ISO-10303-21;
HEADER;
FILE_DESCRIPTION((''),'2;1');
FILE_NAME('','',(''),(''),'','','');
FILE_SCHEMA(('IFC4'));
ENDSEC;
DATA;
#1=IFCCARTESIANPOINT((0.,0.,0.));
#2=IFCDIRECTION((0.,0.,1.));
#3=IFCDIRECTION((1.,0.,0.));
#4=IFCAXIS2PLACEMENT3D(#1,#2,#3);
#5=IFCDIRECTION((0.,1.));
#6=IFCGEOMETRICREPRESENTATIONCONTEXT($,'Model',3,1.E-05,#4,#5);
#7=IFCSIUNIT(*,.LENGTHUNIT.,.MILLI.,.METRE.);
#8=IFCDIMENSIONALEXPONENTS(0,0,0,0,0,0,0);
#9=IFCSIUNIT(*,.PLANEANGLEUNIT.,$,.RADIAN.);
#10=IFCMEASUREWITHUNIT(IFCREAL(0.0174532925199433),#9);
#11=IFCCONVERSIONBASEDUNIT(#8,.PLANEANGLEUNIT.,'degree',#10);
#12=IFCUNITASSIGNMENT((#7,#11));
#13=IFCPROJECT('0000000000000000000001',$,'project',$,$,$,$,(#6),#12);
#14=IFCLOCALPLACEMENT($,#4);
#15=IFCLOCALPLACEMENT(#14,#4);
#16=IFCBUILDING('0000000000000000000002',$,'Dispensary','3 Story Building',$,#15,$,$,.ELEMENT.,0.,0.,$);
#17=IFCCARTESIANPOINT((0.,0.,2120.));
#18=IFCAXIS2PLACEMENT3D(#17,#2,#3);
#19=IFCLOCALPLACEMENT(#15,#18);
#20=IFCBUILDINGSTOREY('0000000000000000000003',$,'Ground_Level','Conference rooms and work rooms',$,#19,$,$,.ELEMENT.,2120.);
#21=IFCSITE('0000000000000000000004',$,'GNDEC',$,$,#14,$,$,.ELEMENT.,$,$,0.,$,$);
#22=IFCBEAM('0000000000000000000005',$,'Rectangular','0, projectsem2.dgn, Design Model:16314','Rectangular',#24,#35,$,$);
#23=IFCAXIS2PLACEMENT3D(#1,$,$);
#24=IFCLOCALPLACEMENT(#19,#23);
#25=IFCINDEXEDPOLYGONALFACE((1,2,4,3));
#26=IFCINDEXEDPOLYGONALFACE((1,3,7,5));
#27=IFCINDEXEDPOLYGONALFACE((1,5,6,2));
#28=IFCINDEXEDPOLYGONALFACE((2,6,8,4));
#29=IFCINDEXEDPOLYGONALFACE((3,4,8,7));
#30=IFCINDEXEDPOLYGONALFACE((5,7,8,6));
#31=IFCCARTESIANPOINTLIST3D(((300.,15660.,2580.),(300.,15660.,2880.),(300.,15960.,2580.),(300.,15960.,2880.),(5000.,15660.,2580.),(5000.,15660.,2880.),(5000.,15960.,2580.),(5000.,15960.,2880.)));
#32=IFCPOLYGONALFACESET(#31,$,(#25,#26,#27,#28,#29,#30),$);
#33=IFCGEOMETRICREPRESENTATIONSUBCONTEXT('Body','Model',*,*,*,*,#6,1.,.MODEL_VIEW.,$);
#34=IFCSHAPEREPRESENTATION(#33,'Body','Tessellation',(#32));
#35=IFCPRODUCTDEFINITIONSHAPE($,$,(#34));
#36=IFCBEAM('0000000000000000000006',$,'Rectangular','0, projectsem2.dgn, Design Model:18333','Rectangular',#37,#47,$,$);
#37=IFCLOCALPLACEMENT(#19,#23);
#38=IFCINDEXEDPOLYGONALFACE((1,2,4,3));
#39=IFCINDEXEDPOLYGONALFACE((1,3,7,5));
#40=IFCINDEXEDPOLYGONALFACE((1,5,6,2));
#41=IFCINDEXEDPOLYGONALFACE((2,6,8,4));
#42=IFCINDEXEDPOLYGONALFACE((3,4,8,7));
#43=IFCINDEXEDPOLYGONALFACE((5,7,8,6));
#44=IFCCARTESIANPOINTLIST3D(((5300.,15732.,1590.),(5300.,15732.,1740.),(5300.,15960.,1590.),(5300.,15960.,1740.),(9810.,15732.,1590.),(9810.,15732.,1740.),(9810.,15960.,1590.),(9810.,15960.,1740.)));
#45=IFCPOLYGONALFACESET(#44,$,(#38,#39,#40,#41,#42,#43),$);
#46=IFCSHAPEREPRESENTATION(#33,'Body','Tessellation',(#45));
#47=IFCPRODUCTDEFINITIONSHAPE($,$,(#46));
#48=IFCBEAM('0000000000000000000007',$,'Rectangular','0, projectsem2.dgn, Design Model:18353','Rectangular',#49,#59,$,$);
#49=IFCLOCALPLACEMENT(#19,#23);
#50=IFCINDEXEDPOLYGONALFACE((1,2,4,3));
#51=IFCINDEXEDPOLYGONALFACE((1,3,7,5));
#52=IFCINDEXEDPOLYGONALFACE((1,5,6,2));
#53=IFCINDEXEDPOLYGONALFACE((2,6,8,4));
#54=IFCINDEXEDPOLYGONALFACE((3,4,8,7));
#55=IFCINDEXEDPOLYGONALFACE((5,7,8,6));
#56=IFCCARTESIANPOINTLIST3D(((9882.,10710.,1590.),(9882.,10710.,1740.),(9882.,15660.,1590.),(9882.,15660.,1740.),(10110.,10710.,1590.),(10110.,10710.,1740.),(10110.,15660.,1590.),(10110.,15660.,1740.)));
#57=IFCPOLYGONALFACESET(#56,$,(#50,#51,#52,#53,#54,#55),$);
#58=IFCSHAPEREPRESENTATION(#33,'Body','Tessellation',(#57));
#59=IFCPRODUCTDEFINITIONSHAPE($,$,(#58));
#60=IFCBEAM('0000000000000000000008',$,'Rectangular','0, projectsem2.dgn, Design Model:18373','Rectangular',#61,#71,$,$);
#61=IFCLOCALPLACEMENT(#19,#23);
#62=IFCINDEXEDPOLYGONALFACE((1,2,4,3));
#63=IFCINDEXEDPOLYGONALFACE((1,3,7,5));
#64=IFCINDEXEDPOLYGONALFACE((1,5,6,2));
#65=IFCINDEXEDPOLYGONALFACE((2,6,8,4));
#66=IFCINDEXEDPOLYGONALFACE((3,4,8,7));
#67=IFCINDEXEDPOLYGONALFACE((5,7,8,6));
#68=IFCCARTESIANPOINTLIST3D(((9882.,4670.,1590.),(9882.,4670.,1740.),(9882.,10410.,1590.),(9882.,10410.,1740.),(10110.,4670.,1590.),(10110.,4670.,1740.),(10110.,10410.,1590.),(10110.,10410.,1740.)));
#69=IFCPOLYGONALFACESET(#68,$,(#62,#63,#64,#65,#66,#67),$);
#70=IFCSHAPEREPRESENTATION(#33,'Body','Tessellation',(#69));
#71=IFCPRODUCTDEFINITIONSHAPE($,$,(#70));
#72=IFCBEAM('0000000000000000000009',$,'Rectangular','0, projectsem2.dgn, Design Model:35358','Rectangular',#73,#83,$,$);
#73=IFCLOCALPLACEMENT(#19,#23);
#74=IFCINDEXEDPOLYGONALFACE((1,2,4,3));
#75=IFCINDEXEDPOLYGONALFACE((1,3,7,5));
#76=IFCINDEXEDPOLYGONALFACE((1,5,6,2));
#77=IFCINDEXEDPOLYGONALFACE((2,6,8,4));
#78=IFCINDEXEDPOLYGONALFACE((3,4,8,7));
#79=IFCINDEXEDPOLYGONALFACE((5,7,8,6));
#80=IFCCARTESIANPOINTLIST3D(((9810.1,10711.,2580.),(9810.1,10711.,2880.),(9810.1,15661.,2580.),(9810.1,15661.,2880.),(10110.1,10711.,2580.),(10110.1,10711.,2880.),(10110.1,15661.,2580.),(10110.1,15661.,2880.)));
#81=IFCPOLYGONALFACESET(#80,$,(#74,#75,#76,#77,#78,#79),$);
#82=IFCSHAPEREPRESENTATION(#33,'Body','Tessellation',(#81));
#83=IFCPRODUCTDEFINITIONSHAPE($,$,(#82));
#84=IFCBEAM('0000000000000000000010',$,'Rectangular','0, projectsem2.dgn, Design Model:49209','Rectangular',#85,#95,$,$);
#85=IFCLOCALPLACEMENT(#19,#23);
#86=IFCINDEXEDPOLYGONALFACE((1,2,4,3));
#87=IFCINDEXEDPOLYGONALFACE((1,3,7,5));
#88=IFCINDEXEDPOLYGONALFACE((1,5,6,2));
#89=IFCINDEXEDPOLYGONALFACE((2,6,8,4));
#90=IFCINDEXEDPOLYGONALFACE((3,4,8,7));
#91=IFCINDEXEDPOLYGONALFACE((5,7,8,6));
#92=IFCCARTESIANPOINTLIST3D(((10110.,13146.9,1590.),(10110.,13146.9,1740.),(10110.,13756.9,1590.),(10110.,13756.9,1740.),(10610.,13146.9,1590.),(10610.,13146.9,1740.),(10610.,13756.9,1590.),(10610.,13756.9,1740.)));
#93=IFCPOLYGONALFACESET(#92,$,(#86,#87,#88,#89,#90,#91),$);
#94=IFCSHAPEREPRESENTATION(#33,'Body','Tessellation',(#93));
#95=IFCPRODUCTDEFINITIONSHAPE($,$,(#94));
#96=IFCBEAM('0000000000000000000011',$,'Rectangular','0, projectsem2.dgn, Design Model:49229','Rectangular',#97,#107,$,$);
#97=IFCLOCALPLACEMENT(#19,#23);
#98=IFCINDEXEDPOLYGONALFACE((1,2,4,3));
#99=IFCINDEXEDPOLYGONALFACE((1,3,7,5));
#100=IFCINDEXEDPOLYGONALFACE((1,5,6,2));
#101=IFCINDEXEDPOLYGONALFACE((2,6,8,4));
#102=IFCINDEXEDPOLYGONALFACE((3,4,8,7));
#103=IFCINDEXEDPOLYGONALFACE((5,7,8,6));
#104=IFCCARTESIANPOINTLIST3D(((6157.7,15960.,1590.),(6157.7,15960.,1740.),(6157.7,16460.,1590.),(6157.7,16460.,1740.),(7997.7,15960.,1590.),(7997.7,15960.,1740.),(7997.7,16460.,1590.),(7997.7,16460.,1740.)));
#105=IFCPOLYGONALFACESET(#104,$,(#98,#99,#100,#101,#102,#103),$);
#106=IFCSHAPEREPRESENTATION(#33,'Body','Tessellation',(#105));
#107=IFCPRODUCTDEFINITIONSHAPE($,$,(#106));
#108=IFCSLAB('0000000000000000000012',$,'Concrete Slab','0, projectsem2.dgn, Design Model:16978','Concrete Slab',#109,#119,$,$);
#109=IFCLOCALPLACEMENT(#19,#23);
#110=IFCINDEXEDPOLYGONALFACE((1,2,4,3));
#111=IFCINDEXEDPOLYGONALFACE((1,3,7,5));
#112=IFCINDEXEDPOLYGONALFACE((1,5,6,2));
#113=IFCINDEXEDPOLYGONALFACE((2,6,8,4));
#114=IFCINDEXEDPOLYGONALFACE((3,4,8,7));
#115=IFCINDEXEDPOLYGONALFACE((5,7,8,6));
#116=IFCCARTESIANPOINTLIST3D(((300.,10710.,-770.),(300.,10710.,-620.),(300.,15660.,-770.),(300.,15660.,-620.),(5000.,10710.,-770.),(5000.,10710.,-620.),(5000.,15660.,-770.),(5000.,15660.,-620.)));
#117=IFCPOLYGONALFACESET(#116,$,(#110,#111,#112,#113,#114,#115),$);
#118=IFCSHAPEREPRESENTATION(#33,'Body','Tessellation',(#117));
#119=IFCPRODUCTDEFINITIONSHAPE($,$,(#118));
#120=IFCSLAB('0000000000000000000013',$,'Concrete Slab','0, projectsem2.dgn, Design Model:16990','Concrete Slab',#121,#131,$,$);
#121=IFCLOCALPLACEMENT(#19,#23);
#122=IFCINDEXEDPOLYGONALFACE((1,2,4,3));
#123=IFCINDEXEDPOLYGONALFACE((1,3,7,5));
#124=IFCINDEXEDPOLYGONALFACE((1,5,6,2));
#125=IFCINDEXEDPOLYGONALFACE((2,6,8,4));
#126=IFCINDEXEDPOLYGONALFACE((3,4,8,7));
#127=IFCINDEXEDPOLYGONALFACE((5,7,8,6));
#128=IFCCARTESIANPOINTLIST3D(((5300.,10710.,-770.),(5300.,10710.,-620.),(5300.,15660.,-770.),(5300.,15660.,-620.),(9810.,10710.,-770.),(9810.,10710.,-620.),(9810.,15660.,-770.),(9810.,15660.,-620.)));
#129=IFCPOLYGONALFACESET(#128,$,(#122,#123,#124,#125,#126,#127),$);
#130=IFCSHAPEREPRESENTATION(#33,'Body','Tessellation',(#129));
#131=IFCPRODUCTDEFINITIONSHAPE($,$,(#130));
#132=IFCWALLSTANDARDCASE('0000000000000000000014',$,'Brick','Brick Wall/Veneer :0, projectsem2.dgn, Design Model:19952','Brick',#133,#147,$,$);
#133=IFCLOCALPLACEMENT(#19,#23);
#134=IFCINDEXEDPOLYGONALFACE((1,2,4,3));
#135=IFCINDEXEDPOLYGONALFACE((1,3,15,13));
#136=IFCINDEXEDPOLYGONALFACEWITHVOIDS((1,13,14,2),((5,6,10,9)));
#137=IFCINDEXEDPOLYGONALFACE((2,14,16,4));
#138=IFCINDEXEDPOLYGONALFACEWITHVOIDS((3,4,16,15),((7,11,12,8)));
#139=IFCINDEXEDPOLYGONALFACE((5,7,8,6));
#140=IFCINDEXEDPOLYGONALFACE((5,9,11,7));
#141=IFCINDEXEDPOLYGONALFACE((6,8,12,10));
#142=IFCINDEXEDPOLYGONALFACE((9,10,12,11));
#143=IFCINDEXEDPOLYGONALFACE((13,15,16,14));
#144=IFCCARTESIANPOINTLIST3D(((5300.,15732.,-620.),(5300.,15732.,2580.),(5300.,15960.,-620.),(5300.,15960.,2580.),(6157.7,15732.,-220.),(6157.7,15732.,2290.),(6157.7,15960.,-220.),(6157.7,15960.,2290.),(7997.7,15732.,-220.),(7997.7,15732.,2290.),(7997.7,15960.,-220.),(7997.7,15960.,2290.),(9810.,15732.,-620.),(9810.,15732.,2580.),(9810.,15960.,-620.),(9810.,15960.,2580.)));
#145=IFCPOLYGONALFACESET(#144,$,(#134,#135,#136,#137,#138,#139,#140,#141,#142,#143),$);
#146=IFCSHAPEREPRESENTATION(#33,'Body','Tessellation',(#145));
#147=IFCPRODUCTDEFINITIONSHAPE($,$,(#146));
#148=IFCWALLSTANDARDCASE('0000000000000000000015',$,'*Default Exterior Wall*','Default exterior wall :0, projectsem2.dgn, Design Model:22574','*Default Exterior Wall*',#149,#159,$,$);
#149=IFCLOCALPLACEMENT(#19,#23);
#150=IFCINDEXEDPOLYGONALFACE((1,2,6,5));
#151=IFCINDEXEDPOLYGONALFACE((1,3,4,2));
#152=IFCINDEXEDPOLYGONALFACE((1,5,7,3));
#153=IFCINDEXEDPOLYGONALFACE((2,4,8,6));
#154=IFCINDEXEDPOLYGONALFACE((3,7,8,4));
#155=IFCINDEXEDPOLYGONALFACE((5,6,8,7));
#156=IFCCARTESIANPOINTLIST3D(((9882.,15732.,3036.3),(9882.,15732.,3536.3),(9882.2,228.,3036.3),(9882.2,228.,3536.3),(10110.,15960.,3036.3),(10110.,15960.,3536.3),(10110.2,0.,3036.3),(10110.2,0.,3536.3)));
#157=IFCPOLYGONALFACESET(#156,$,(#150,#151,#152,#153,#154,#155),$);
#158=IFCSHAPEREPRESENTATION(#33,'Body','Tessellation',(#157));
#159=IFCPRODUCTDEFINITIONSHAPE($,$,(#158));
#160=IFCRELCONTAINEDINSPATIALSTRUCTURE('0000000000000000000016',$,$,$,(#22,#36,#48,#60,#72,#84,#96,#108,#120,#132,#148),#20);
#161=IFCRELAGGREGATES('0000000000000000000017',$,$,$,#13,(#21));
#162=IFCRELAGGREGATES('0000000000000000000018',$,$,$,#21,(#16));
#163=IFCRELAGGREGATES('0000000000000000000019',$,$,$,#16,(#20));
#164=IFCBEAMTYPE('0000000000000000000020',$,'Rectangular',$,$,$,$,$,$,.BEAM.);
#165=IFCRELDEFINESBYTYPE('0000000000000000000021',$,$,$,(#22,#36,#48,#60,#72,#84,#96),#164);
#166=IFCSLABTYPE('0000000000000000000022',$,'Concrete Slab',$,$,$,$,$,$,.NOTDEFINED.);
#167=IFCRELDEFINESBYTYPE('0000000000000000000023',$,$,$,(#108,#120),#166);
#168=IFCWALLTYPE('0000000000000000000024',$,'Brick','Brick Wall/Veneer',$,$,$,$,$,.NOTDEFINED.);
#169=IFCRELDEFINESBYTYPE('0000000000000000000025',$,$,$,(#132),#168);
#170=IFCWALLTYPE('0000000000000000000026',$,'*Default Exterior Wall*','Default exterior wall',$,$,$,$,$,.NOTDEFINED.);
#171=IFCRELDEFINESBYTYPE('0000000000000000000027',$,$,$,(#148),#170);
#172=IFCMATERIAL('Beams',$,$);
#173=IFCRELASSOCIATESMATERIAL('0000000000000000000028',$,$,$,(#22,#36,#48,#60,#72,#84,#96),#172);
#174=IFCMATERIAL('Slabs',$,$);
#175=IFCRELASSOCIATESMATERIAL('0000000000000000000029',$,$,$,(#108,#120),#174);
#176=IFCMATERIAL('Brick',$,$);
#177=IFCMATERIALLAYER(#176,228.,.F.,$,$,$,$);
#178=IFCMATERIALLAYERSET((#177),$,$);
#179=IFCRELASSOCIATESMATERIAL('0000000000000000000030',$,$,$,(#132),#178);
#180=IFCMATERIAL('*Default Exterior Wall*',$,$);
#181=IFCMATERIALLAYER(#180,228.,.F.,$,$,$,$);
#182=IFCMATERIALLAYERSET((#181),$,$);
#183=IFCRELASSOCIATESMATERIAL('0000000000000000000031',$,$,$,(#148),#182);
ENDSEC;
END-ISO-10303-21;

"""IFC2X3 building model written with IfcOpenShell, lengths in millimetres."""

from ifc_helpers import new_model, entity, si_unit, converted_unit, direction, frame, frame_2d, origin_with_axes, place, context, subcontext, project, spatial, polyline, rectangle, outline, extrude, material, layer, layer_set, layer_usage, type_object, element, save


model = new_model("IFC2X3")

# Units and contexts
model_context = context("Model", 3, precision=1e-05, world=origin_with_axes(), true_north=direction((0.0, 1.0)))
body_context = subcontext(model_context, "Body", "Model", "MODEL_VIEW", scale=1.0)
ifc_project = project(units=[si_unit("LENGTHUNIT", "METRE", prefix="MILLI"), converted_unit("PLANEANGLEUNIT", "degree", entity("IfcReal", 0.0174532925199433), si_unit("PLANEANGLEUNIT", "RADIAN"), dimensions=[0, 0, 0, 0, 0, 0, 0])], contexts=[model_context])

# Site, building, storey
site_placement = place(None, origin_with_axes())
site = spatial("IfcSite", under=ifc_project, at=site_placement, Name="GNDEC", CompositionType="ELEMENT", RefElevation=0.0)
building_placement = place(site_placement, origin_with_axes())
building = spatial("IfcBuilding", under=site, at=building_placement, Name="Dispensary", Description="3 Story Building", CompositionType="ELEMENT", ElevationOfRefHeight=0.0, ElevationOfTerrain=0.0)
storey_placement = place(building_placement, frame((0.0, 0.0, 2120.0), z_axis=(0.0, 0.0, 1.0), x_axis=(1.0, 0.0, 0.0)))
storey = spatial("IfcBuildingStorey", under=building, at=storey_placement, Name="Ground_Level", Description="Conference rooms and work rooms", CompositionType="ELEMENT", Elevation=2120.0)

# Beams
ifc_material_1 = material(Name="Beams")
beam_type = type_object("IfcBeamType", Name="Rectangular", PredefinedType="BEAM")
beam_1_placement = place(storey_placement, frame((5000.0, 15660.0, 2580.0), z_axis=(-1.0, 0.0, 0.0), x_axis=(0.0, 0.0, 1.0)))
element("IfcBeam", 1, at=beam_1_placement, inside=storey, type_object=beam_type, material=ifc_material_1, Name="Rectangular", Description="0, projectsem2.dgn, Design Model:16314", ObjectType="Rectangular", context=body_context, shape_type="SweptSolid", body=[
    extrude(rectangle(XDim=300.0, YDim=300.0, at=frame_2d((150.0, 150.0), x_axis=(0.0, 1.0))), origin_with_axes(), (0.0, 0.0, 1.0), 4700.0),
])
beam_2_placement = place(storey_placement, frame((5300.0, 15732.0, 1590.0), z_axis=(1.0, 0.0, 0.0), x_axis=(0.0, 1.0, 0.0)))
element("IfcBeam", 2, at=beam_2_placement, inside=storey, type_object=beam_type, material=ifc_material_1, Name="Rectangular", Description="0, projectsem2.dgn, Design Model:18333", ObjectType="Rectangular", context=body_context, shape_type="SweptSolid", body=[
    extrude(rectangle(XDim=150.0, YDim=228.0, at=frame_2d((114.0, 75.0), x_axis=(0.0, 1.0))), origin_with_axes(), (0.0, 0.0, 1.0), 4510.0),
])
beam_3_placement = place(storey_placement, frame((9882.0, 15660.0, 1590.0), z_axis=(0.0, -1.0, 0.0), x_axis=(1.0, 0.0, 0.0)))
element("IfcBeam", 3, at=beam_3_placement, inside=storey, type_object=beam_type, material=ifc_material_1, Name="Rectangular", Description="0, projectsem2.dgn, Design Model:18353", ObjectType="Rectangular", context=body_context, shape_type="SweptSolid", body=[
    extrude(rectangle(XDim=150.0, YDim=228.0, at=frame_2d((114.0, 75.0), x_axis=(0.0, 1.0))), origin_with_axes(), (0.0, 0.0, 1.0), 4950.0),
])
beam_4_placement = place(storey_placement, frame((9882.0, 10410.0, 1590.0), z_axis=(0.0, -1.0, 0.0), x_axis=(1.0, 0.0, 0.0)))
element("IfcBeam", 4, at=beam_4_placement, inside=storey, type_object=beam_type, material=ifc_material_1, Name="Rectangular", Description="0, projectsem2.dgn, Design Model:18373", ObjectType="Rectangular", context=body_context, shape_type="SweptSolid", body=[
    extrude(rectangle(XDim=150.0, YDim=228.0, at=frame_2d((114.0, 75.0), x_axis=(0.0, 1.0))), origin_with_axes(), (0.0, 0.0, 1.0), 5740.0),
])
beam_5_placement = place(storey_placement, frame((10110.1, 15661.0, 2580.0), z_axis=(0.0, -1.0, 0.0), x_axis=(0.0, 0.0, 1.0)))
element("IfcBeam", 5, at=beam_5_placement, inside=storey, type_object=beam_type, material=ifc_material_1, Name="Rectangular", Description="0, projectsem2.dgn, Design Model:35358", ObjectType="Rectangular", context=body_context, shape_type="SweptSolid", body=[
    extrude(rectangle(XDim=300.0, YDim=300.0, at=frame_2d((150.0, 150.0), x_axis=(0.0, 1.0))), origin_with_axes(), (0.0, 0.0, 1.0), 4950.0),
])
beam_6_placement = place(storey_placement, frame((10610.0, 13146.9, 1590.0), z_axis=(-0.000011, 1.0, 0.0), x_axis=(-1.0, -0.000011, 0.0)))
element("IfcBeam", 6, at=beam_6_placement, inside=storey, type_object=beam_type, material=ifc_material_1, Name="Rectangular", Description="0, projectsem2.dgn, Design Model:49209", ObjectType="Rectangular", context=body_context, shape_type="SweptSolid", body=[
    extrude(rectangle(XDim=150.0, YDim=500.0, at=frame_2d((250.0, 75.0), x_axis=(0.0, 1.0))), origin_with_axes(), (0.0, 0.0, 1.0), 610.0),
])
beam_7_placement = place(storey_placement, frame((7997.7, 16460.0, 1590.0), z_axis=(-1.0, 0.0, 0.0), x_axis=(0.0, -1.0, 0.0)))
element("IfcBeam", 7, at=beam_7_placement, inside=storey, type_object=beam_type, material=ifc_material_1, Name="Rectangular", Description="0, projectsem2.dgn, Design Model:49229", ObjectType="Rectangular", context=body_context, shape_type="SweptSolid", body=[
    extrude(rectangle(XDim=150.0, YDim=500.0, at=frame_2d((250.0, 75.0), x_axis=(0.0, 1.0))), origin_with_axes(), (0.0, 0.0, 1.0), 1840.0),
])

# Slabs
ifc_material_2 = material(Name="Slabs")
slab_type = type_object("IfcSlabType", Name="Concrete Slab", PredefinedType="NOTDEFINED")
slab_placement = place(storey_placement, frame((5000.0, 10710.0, -620.0), z_axis=(0.0, 0.0, -1.0), x_axis=(-1.0, 0.0, 0.0)))
element("IfcSlab", 8, at=slab_placement, inside=storey, type_object=slab_type, material=ifc_material_2, Name="Concrete Slab", Description="0, projectsem2.dgn, Design Model:16978", ObjectType="Concrete Slab", context=body_context, shape_type="SweptSolid", body=[
    extrude(rectangle(XDim=4700.0, YDim=4950.0, at=frame_2d((2350.0, 2475.0), x_axis=(1.0, 0.0))), origin_with_axes(), (0.0, 0.0, 1.0), 150.0),
])
for number, where, z_axis, x_axis, name in (
    (9, (5300.0, 15660.0, -620.0), (0.0, 0.0, -1.0), (1.0, 0.0, 0.0), "Concrete Slab"),
):
    element("IfcSlab", number, at=place(storey_placement, frame(where, z_axis=z_axis, x_axis=x_axis)), inside=storey, type_object=slab_type, material=ifc_material_2, Name=name, Description="0, projectsem2.dgn, Design Model:16990", ObjectType="Concrete Slab", context=body_context, shape_type="SweptSolid", body=[
        extrude(rectangle(XDim=4510.0, YDim=4950.0, at=frame_2d((2255.0, 2475.0), x_axis=(1.0, 0.0))), origin_with_axes(), (0.0, 0.0, 1.0), 150.0),
    ])

# Wall, opening
ifc_material_3 = material(Name="Brick")
ifc_layer_1 = layer(ifc_material_3, 228.0, ventilated=False)
ifc_layer_set_1 = layer_set([ifc_layer_1])
ifc_layer_usage_1 = layer_usage(ifc_layer_set_1, "AXIS2", "POSITIVE", 0.0)
wall_type_1 = type_object("IfcWallType", Name="Brick", Description="Brick Wall/Veneer", PredefinedType="NOTDEFINED")
wall_1_placement = place(storey_placement, frame((5300.0, 15960.0, -620.0), z_axis=(0.0, 0.0, 1.0), x_axis=(1.0, 0.0, 0.0)))
wall_1 = element("IfcWallStandardCase", 10, at=wall_1_placement, inside=storey, type_object=wall_type_1, material=ifc_layer_usage_1, Name="Brick", Description="Brick Wall/Veneer :0, projectsem2.dgn, Design Model:19952", ObjectType="Brick", context=body_context, shape_type="SweptSolid", body=[
    extrude(rectangle(XDim=4510.0, YDim=228.0, at=frame_2d((2255.0, -114.0), x_axis=(-1.0, 0.0))), origin_with_axes(), (0.0, 0.0, 1.0), 3200.0),
])
opening_placement = place(wall_1_placement, frame((857.7, -228.0, 400.0), z_axis=(0.0, 0.0, 1.0), x_axis=(1.0, 0.0, 0.0)))
element("IfcOpeningElement", 11, at=opening_placement, cuts=wall_1, ObjectType="Opening", context=body_context, shape_type="SweptSolid", body=[
    extrude(rectangle(XDim=2510.0, YDim=1840.0, at=frame_2d((-920.0, 1255.0), x_axis=(0.0, -1.0))), frame((0.0, 0.0, 0.0), z_axis=(0.0, 1.0, 0.0), x_axis=(-1.0, 0.0, 0.0)), (0.0, 0.0, 1.0), 228.0),
])

# Wall
ifc_material_4 = material(Name="*Default Exterior Wall*")
ifc_layer_2 = layer(ifc_material_4, 228.0, ventilated=False)
ifc_layer_set_2 = layer_set([ifc_layer_2])
ifc_layer_usage_2 = layer_usage(ifc_layer_set_2, "AXIS2", "POSITIVE", 0.0)
wall_type_2 = type_object("IfcWallType", Name="*Default Exterior Wall*", Description="Default exterior wall", PredefinedType="NOTDEFINED")
wall_2_placement = place(storey_placement, frame((10110.0, 15960.0, 3036.3), z_axis=(0.0, 0.0, 1.0), x_axis=(0.000011, -1.0, 0.0)))
element("IfcWallStandardCase", 12, at=wall_2_placement, inside=storey, type_object=wall_type_2, material=ifc_layer_usage_2, Name="*Default Exterior Wall*", Description="Default exterior wall :0, projectsem2.dgn, Design Model:22574", ObjectType="*Default Exterior Wall*", context=body_context, shape_type="SweptSolid", body=[
    extrude(outline(polyline([(15960.0, 0.0), (0.0, 0.0), (228.0, -228.0), (15732.0, -228.0), (15960.0, 0.0)])), origin_with_axes(), (0.0, 0.0, 1.0), 500.0),
])

save(model, "model.ifc")
